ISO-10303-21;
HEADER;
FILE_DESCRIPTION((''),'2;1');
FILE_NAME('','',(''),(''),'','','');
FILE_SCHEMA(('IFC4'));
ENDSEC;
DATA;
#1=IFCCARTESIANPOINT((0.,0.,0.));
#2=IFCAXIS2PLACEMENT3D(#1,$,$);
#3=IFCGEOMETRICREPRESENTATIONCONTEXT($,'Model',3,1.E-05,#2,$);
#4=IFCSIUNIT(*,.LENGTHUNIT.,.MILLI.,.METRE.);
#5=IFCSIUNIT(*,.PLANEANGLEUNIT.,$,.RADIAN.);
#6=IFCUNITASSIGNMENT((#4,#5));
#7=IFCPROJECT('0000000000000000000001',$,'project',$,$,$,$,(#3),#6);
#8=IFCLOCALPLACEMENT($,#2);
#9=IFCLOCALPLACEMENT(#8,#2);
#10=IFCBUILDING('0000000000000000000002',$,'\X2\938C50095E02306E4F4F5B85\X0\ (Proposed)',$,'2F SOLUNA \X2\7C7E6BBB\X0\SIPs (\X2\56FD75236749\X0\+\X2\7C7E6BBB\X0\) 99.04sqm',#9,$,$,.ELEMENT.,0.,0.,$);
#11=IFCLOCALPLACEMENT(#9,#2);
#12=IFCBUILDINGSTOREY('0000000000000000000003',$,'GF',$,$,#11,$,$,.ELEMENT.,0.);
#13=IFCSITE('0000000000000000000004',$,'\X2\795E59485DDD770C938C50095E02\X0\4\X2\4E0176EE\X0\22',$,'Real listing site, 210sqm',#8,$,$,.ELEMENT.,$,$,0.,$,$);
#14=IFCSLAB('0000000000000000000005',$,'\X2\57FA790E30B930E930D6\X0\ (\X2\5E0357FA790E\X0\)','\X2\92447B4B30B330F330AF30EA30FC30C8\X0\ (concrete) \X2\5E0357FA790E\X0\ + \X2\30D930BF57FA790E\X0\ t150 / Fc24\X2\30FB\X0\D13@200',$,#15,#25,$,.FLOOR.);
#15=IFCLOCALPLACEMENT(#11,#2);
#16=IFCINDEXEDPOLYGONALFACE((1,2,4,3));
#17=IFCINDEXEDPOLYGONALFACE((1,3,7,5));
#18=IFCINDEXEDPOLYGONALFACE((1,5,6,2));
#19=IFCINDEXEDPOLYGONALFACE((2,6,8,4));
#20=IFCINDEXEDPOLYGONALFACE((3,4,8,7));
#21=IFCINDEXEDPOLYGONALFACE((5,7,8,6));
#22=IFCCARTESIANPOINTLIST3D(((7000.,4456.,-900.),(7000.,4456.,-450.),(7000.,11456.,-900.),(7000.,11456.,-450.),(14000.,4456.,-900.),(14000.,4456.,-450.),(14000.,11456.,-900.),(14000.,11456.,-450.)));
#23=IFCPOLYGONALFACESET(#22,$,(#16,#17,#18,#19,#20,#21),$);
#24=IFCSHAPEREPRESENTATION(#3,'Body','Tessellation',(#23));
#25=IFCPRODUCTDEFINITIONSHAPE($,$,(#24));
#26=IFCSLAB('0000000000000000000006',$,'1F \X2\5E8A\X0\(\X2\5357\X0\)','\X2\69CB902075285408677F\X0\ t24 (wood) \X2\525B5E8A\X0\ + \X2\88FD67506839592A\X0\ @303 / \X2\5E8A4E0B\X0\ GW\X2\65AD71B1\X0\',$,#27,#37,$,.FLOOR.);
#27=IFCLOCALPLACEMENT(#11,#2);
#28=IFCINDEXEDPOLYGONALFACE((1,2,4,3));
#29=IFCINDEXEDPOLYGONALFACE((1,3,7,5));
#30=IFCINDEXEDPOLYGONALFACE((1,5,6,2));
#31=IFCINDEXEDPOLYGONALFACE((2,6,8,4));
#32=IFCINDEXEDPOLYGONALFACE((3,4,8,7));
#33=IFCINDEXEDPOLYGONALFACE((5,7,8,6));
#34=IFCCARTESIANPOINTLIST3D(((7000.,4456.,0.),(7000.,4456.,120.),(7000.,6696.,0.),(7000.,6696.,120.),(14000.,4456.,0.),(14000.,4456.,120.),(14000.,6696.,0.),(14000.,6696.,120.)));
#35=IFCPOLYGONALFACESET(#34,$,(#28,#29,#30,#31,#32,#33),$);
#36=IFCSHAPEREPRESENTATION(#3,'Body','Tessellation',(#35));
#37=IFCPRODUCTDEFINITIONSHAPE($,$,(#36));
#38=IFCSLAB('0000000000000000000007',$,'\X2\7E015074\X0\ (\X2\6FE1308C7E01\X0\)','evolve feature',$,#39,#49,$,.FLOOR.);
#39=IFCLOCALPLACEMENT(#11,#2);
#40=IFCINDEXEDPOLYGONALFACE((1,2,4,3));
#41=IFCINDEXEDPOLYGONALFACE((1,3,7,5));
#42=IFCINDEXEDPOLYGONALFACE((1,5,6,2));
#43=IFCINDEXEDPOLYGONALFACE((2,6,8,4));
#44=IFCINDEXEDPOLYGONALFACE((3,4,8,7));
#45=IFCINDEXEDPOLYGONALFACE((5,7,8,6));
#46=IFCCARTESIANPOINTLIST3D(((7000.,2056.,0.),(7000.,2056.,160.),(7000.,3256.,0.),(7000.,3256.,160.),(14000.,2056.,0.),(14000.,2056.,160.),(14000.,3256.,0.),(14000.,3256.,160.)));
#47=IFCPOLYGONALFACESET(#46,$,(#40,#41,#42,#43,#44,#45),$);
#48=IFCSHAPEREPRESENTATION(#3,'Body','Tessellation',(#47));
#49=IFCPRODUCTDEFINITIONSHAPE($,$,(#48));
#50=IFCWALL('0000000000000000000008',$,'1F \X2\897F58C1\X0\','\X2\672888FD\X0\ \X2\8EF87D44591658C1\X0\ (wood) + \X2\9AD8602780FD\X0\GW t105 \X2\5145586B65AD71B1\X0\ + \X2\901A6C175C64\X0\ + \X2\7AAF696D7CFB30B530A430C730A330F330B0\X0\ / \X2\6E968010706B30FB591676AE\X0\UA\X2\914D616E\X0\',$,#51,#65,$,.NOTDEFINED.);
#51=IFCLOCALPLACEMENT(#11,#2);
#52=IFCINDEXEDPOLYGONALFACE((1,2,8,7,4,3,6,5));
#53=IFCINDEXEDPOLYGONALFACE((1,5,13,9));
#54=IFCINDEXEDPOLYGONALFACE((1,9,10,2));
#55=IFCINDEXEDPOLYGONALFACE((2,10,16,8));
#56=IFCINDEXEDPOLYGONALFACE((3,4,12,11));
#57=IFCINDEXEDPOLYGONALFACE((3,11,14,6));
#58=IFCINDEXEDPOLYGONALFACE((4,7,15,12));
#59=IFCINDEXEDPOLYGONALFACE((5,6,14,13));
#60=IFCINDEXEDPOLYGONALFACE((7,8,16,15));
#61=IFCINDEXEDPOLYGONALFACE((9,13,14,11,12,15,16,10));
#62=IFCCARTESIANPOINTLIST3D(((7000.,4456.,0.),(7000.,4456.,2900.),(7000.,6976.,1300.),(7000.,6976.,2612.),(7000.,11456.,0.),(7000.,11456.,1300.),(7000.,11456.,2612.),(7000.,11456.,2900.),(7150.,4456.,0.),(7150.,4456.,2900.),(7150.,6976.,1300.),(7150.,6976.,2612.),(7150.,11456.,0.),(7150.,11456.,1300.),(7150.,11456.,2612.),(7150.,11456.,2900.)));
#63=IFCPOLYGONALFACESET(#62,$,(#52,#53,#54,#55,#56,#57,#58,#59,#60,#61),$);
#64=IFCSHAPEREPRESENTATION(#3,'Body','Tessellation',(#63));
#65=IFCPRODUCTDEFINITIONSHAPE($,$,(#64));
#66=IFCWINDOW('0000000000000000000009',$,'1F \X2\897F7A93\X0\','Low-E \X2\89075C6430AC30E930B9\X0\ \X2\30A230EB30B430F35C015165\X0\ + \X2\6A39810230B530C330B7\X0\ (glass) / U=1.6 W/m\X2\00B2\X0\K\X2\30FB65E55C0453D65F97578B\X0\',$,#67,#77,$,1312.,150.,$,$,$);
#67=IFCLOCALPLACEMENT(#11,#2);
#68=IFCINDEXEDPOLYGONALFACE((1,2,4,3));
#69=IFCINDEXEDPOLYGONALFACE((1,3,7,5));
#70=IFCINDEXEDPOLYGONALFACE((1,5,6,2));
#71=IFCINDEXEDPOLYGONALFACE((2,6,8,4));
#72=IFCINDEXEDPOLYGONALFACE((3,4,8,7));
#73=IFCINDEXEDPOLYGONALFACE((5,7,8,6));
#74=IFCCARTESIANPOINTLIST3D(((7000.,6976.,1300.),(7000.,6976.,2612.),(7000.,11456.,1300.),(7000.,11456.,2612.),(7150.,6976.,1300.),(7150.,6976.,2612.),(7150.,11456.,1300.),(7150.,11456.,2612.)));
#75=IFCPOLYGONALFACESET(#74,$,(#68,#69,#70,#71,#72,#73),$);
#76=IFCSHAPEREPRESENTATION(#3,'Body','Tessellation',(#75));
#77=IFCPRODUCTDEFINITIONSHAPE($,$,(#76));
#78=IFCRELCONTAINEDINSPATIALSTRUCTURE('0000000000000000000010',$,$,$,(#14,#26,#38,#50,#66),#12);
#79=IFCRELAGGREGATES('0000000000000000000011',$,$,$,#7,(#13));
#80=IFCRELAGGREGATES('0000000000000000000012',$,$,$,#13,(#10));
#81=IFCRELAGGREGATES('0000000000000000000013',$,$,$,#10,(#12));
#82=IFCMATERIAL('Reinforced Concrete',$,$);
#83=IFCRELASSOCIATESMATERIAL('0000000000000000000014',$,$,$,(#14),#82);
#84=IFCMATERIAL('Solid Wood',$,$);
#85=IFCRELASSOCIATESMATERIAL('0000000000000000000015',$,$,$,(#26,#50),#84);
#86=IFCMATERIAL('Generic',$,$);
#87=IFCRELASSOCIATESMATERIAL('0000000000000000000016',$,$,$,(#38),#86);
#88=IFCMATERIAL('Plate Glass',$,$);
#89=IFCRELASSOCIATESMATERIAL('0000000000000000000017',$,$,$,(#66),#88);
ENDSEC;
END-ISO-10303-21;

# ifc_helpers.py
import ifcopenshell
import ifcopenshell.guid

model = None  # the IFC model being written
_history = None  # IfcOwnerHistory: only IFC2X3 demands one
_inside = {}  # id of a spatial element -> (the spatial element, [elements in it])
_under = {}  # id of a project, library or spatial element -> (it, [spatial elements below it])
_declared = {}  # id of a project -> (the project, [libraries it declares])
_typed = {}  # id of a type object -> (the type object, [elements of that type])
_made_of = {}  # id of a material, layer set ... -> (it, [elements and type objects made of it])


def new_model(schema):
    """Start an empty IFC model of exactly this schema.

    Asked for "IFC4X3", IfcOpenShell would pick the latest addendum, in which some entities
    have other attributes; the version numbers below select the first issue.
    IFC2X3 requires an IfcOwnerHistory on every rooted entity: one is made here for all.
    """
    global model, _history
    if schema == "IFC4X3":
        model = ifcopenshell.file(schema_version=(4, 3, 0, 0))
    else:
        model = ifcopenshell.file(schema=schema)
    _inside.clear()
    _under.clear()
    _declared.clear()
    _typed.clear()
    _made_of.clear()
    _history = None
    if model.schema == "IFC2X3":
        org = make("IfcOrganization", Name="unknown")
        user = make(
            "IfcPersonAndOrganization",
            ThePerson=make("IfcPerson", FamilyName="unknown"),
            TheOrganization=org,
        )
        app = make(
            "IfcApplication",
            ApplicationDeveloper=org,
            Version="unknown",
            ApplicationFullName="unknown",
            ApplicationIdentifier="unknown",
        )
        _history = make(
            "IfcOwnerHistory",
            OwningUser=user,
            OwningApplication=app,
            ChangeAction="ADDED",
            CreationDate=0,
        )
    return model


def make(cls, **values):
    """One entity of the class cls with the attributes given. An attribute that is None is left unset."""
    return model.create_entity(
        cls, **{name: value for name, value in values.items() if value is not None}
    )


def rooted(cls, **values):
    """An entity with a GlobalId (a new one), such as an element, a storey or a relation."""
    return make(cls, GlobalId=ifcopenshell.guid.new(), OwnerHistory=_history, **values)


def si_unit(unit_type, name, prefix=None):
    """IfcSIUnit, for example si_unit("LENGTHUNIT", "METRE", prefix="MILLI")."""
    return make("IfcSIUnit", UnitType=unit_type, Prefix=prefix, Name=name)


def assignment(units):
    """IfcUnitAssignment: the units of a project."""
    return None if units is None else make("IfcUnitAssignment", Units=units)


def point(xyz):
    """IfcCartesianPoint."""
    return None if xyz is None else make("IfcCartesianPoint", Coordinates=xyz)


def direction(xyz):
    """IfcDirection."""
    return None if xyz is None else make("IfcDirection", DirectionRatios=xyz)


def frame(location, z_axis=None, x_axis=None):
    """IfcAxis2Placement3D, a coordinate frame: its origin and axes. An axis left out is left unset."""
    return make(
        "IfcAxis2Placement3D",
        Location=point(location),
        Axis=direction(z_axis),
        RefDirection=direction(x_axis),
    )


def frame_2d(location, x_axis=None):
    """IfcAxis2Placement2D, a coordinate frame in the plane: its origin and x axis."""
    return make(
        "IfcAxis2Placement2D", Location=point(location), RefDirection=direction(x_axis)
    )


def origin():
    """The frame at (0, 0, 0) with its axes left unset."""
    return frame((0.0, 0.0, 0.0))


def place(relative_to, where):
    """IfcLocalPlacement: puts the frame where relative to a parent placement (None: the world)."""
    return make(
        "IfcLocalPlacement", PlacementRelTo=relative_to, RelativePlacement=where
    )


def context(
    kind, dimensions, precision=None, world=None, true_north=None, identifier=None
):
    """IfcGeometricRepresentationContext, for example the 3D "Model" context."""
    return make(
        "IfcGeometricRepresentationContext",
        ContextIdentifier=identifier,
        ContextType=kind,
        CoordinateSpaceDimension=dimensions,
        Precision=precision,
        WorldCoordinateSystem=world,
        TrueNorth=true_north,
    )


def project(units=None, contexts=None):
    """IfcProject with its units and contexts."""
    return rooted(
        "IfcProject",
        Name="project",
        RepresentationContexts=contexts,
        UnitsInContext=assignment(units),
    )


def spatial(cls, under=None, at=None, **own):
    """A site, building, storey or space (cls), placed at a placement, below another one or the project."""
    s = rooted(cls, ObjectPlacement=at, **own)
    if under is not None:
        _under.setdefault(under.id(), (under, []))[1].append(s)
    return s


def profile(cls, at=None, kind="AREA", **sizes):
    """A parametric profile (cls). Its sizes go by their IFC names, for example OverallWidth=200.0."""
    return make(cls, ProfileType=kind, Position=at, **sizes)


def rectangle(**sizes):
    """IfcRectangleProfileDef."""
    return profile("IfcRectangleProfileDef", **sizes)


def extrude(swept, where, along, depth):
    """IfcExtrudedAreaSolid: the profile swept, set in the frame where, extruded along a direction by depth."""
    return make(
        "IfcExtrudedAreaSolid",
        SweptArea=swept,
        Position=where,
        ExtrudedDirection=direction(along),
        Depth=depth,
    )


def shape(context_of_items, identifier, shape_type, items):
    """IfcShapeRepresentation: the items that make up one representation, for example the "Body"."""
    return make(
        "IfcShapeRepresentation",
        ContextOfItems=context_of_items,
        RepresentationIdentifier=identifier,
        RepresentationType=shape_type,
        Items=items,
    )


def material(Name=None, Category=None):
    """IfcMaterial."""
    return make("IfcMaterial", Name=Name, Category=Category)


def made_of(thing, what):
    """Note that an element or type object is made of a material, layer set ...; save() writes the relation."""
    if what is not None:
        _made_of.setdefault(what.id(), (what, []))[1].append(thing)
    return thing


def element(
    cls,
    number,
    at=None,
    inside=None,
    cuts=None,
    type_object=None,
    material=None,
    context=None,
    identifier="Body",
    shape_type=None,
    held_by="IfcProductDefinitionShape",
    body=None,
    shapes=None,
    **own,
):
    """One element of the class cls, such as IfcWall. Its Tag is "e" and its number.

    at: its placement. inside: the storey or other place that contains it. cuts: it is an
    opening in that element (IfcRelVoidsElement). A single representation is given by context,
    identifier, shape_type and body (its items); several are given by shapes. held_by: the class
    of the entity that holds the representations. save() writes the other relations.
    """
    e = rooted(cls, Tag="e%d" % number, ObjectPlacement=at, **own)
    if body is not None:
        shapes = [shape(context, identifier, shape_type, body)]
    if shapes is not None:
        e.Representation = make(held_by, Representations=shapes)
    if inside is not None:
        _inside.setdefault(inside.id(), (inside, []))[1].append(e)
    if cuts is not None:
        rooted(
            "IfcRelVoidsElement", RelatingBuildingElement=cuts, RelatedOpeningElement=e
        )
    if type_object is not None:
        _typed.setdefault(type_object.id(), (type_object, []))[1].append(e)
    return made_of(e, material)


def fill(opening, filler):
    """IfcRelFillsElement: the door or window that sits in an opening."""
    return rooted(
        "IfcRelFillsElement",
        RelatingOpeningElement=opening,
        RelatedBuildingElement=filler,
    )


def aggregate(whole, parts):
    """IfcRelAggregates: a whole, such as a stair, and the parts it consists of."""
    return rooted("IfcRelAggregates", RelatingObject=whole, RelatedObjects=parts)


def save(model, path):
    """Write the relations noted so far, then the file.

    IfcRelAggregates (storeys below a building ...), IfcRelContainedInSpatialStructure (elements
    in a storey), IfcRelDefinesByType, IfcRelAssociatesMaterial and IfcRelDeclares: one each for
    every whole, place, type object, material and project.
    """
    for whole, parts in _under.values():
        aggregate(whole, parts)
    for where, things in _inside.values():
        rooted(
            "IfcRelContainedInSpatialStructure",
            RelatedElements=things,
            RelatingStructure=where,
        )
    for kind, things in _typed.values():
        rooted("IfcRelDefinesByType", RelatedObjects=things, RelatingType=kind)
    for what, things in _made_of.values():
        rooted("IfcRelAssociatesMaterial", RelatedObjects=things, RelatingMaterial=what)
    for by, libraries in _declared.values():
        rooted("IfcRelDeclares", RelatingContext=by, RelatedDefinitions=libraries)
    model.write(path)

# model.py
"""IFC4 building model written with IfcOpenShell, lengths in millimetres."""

from ifc_helpers import new_model, si_unit, frame, frame_2d, origin, place, context, project, spatial, rectangle, extrude, material, element, fill, save


model = new_model("IFC4")

# Units and contexts
model_context = context("Model", 3, precision=1e-05, world=origin())
ifc_project = project(units=[si_unit("LENGTHUNIT", "METRE", prefix="MILLI"), si_unit("PLANEANGLEUNIT", "RADIAN")], contexts=[model_context])

# Site, building, storey
site_placement = place(None, origin())
site = spatial("IfcSite", under=ifc_project, at=site_placement, Name="神奈川県鎌倉市4丁目22", ObjectType="Real listing site, 210sqm", CompositionType="ELEMENT", RefElevation=0.0)
building_placement = place(site_placement, origin())
building = spatial("IfcBuilding", under=site, at=building_placement, Name="鎌倉市の住宅 (Proposed)", ObjectType="2F SOLUNA 籾殻SIPs (国産杉+籾殻) 99.04sqm", CompositionType="ELEMENT", ElevationOfRefHeight=0.0, ElevationOfTerrain=0.0)
storey_placement = place(building_placement, origin())
storey = spatial("IfcBuildingStorey", under=building, at=storey_placement, Name="GF", CompositionType="ELEMENT", Elevation=0.0)

# Slabs
ifc_material_1 = material(Name="Reinforced Concrete")
slab_1_placement = place(storey_placement, frame((3500.0, 2228.0, -450.0)))
element("IfcSlab", 1, at=slab_1_placement, inside=storey, material=ifc_material_1, Name="基礎スラブ (布基礎)", Description="鉄筋コンクリート (concrete) 布基礎 + ベタ基礎 t150 / Fc24・D13@200", PredefinedType="FLOOR", context=model_context, shape_type="SweptSolid", body=[
    extrude(rectangle(XDim=7000.0, YDim=7000.0, at=frame_2d((3500.0, 3500.0))), frame((3500.0, 2228.0, -450.0)), (0.0, 0.0, 1.0), 450.0),
])
ifc_material_2 = material(Name="Solid Wood")
slab_2_placement = place(storey_placement, frame((3500.0, 2228.0, 0.0)))
element("IfcSlab", 2, at=slab_2_placement, inside=storey, material=ifc_material_2, Name="1F 床(南)", Description="構造用合板 t24 (wood) 剛床 + 製材根太 @303 / 床下 GW断熱", PredefinedType="FLOOR", context=model_context, shape_type="SweptSolid", body=[
    extrude(rectangle(XDim=7000.0, YDim=2240.0, at=frame_2d((3500.0, 1120.0))), frame((3500.0, 2228.0, 0.0)), (0.0, 0.0, 1.0), 120.0),
])
ifc_material_3 = material(Name="Generic")
slab_3_placement = place(storey_placement, frame((3500.0, 1028.0, 0.0)))
element("IfcSlab", 3, at=slab_3_placement, inside=storey, material=ifc_material_3, Name="縁側 (濡れ縁)", Description="evolve feature", PredefinedType="FLOOR", context=model_context, shape_type="SweptSolid", body=[
    extrude(rectangle(XDim=7000.0, YDim=1200.0, at=frame_2d((3500.0, 600.0))), frame((3500.0, 1028.0, 0.0)), (0.0, 0.0, 1.0), 160.0),
])

# Shared definitions
ifc_material_4 = material(Name="Plate Glass")

# Wall, opening, window
wall_1_placement = place(storey_placement, frame((3500.0, 2228.0, 0.0)))
wall_1 = element("IfcWall", 4, at=wall_1_placement, inside=storey, material=ifc_material_2, Name="1F 西壁", Description="木製 軸組外壁 (wood) + 高性能GW t105 充填断熱 + 通気層 + 窯業系サイディング / 準耐火・外皮UA配慮", PredefinedType="NOTDEFINED", context=model_context, shape_type="SweptSolid", body=[
    extrude(rectangle(XDim=150.0, YDim=7000.0, at=frame_2d((75.0, 3500.0))), frame((3500.0, 2228.0, 0.0)), (0.0, 0.0, 1.0), 2900.0),
])
opening_1_placement = place(storey_placement, frame((3500.0, 3488.0, 650.0)))
opening_1 = element("IfcOpeningElement", 5, at=opening_1_placement, cuts=wall_1, PredefinedType="NOTDEFINED", context=model_context, shape_type="SweptSolid", body=[
    extrude(rectangle(XDim=150.0, YDim=4480.0, at=frame_2d((75.0, 2240.0))), frame((3500.0, 3488.0, 650.0)), (0.0, 0.0, 1.0), 1312.0),
])
window_1_placement = place(storey_placement, frame((3500.0, 3488.0, 650.0)))
window_1 = element("IfcWindow", 6, at=window_1_placement, inside=storey, material=ifc_material_4, Name="1F 西窓", Description="Low-E 複層ガラス アルゴン封入 + 樹脂サッシ (glass) / U=1.6 W/m²K・日射取得型", OverallHeight=1312.0, OverallWidth=150.0, context=model_context, shape_type="SweptSolid", body=[
    extrude(rectangle(XDim=150.0, YDim=4480.0, at=frame_2d((75.0, 2240.0))), frame((3500.0, 3488.0, 650.0)), (0.0, 0.0, 1.0), 1312.0),
])
fill(opening_1, window_1)

save(model, "model.ifc")
